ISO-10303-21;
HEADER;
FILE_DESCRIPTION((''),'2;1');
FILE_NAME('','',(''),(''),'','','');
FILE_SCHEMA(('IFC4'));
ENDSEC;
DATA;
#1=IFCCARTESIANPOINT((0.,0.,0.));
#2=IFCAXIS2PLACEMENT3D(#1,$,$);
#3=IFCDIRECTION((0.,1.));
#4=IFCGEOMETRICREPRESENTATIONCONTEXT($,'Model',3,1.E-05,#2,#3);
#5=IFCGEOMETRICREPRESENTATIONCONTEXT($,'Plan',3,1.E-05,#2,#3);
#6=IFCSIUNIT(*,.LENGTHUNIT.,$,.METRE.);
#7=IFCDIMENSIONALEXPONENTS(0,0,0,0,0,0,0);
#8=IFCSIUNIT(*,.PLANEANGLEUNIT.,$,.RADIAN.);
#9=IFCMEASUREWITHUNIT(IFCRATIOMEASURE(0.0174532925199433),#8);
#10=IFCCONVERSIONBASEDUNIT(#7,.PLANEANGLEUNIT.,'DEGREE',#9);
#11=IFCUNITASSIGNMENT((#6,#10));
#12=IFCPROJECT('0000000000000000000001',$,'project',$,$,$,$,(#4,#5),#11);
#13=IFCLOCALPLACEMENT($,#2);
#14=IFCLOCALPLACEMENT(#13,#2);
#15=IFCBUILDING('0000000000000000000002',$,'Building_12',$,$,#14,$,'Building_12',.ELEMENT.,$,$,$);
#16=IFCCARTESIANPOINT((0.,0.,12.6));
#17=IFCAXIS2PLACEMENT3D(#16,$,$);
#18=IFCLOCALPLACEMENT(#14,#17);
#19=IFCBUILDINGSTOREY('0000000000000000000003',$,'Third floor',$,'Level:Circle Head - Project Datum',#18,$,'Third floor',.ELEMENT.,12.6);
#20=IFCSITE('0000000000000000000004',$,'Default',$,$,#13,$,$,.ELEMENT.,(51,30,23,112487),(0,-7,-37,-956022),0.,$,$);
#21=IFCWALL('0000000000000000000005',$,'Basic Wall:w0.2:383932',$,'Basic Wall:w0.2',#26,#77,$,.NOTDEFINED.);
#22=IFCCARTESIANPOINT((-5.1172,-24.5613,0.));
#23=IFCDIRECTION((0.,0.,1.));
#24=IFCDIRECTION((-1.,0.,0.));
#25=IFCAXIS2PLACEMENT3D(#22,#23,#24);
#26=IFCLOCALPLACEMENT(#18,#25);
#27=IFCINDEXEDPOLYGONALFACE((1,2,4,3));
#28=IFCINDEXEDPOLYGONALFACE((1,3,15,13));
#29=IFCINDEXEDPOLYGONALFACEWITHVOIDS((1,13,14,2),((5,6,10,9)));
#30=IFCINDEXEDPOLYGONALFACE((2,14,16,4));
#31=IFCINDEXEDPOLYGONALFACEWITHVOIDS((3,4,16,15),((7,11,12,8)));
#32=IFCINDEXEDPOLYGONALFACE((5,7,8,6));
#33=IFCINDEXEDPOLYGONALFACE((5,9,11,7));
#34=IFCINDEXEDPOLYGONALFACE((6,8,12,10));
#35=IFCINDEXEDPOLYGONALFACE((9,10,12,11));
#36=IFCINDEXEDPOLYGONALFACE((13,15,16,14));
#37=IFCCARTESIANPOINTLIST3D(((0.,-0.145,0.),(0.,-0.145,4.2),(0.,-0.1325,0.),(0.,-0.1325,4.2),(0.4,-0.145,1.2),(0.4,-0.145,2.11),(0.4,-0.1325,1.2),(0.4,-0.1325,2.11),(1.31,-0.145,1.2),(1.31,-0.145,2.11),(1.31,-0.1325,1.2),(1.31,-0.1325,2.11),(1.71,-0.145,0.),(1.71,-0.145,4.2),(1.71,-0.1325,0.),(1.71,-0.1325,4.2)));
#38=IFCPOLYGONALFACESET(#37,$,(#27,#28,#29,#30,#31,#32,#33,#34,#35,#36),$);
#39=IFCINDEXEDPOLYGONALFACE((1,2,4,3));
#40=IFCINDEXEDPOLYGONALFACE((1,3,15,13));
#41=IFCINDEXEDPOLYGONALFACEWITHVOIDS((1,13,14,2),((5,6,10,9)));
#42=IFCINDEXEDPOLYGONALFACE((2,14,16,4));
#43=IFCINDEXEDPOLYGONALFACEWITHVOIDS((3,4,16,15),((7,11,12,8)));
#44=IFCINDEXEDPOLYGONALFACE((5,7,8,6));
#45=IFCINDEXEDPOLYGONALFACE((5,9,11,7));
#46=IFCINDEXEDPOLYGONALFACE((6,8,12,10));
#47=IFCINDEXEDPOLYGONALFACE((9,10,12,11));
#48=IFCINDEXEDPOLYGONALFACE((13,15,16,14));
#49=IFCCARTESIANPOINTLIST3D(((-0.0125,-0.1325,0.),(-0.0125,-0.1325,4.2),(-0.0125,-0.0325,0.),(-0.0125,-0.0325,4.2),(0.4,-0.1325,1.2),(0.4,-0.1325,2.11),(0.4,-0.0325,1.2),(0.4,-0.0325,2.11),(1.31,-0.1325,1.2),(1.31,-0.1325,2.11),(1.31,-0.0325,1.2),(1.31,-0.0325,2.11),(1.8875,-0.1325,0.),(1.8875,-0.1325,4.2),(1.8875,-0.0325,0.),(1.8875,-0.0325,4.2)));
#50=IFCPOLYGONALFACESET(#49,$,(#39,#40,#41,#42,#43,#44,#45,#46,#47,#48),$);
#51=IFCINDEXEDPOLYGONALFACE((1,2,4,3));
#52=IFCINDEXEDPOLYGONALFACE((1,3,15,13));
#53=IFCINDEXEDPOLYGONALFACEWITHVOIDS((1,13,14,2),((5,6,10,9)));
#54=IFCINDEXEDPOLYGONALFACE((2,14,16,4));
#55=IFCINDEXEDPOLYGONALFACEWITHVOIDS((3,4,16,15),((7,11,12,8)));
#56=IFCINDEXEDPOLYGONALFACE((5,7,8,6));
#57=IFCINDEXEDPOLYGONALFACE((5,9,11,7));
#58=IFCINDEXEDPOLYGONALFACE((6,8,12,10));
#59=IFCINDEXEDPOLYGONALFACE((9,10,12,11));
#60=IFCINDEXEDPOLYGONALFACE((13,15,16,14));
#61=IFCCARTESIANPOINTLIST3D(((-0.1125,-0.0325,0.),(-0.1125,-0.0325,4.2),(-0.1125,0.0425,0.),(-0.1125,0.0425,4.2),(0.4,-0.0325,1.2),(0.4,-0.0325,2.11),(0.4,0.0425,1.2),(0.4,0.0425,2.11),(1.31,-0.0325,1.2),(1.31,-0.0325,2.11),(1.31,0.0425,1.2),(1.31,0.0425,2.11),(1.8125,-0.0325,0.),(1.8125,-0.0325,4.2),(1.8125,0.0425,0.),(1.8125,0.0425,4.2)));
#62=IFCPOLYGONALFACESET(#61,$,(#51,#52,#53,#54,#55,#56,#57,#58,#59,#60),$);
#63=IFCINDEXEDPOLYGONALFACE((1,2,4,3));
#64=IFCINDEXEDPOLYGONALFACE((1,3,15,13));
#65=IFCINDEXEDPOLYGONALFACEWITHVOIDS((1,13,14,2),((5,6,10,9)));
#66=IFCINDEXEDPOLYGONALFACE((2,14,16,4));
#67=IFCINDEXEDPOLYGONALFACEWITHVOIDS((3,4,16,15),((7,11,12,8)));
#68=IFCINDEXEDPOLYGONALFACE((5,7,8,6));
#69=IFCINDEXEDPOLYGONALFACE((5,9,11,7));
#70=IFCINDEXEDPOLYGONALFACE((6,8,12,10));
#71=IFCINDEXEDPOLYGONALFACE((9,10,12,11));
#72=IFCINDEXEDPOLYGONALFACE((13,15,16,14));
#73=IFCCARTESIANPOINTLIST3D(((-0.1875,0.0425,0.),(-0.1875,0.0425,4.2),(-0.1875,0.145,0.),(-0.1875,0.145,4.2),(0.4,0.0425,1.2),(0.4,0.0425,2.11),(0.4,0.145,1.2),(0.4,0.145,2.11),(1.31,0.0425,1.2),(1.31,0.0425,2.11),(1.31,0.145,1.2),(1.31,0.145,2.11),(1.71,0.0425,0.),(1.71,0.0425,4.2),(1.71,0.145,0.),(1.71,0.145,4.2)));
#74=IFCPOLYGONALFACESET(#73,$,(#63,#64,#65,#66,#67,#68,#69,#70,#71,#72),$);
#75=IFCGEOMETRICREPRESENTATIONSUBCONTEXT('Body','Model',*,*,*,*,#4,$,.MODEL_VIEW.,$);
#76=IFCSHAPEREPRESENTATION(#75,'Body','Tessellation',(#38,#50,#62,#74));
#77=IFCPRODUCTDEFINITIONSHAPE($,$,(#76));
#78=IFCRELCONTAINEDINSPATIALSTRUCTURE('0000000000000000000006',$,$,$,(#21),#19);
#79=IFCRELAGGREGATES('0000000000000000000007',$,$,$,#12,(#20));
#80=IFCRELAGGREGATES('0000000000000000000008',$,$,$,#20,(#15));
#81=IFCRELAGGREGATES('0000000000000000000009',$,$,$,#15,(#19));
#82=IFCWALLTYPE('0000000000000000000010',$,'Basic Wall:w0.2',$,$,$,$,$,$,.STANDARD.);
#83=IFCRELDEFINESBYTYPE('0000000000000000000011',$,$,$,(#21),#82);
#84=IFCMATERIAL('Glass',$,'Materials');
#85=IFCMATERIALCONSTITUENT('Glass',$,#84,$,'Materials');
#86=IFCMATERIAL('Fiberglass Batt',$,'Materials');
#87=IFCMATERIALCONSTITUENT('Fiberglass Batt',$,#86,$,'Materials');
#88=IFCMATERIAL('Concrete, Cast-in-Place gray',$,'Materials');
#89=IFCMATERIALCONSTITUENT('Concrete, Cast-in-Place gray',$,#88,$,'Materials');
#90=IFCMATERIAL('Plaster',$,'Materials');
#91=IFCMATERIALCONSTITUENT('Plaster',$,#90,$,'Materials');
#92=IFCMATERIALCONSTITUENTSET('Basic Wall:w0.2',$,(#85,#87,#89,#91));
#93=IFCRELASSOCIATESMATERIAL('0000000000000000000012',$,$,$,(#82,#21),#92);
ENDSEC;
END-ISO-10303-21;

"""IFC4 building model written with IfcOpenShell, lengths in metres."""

from ifc_helpers import new_model, entity, si_unit, converted_unit, direction, frame, origin, place, context, subcontext, project, spatial, indexed_curve, outline, extrude, material, constituent, constituent_set, type_object, element, save


model = new_model("IFC4")

# Units and contexts
model_context = context("Model", 3, precision=1e-05, world=origin(), true_north=direction((0.0, 1.0)))
plan_context = context("Plan", 3, precision=1e-05, world=origin(), true_north=direction((0.0, 1.0)))
body_context = subcontext(model_context, "Body", "Model", "MODEL_VIEW")
ifc_project = project(units=[si_unit("LENGTHUNIT", "METRE"), converted_unit("PLANEANGLEUNIT", "DEGREE", entity("IfcRatioMeasure", 0.0174532925199433), si_unit("PLANEANGLEUNIT", "RADIAN"), dimensions=[0, 0, 0, 0, 0, 0, 0])], contexts=[model_context, plan_context])

# Site, building, storey
site_placement = place(None, origin())
site = spatial("IfcSite", under=ifc_project, at=site_placement, Name="Default", CompositionType="ELEMENT", RefLatitude=(51, 30, 23, 112487), RefLongitude=(0, -7, -37, -956022), RefElevation=0.0)
building_placement = place(site_placement, origin())
building = spatial("IfcBuilding", under=site, at=building_placement, Name="Building_12", LongName="Building_12", CompositionType="ELEMENT")
storey_placement = place(building_placement, frame((0.0, 0.0, 12.6)))
storey = spatial("IfcBuildingStorey", under=building, at=storey_placement, Name="Third floor", ObjectType="Level:Circle Head - Project Datum", LongName="Third floor", CompositionType="ELEMENT", Elevation=12.6)

# Shared definitions
ifc_material_1 = material(Name="Glass", Category="Materials")
ifc_constituent_1 = constituent(ifc_material_1, Name="Glass", Category="Materials")
ifc_material_2 = material(Name="Fiberglass Batt", Category="Materials")
ifc_constituent_2 = constituent(ifc_material_2, Name="Fiberglass Batt", Category="Materials")
ifc_material_3 = material(Name="Concrete, Cast-in-Place gray", Category="Materials")
ifc_constituent_3 = constituent(ifc_material_3, Name="Concrete, Cast-in-Place gray", Category="Materials")
ifc_material_4 = material(Name="Plaster", Category="Materials")
ifc_constituent_4 = constituent(ifc_material_4, Name="Plaster", Category="Materials")
ifc_constituent_set = constituent_set(constituents=[ifc_constituent_1, ifc_constituent_2, ifc_constituent_3, ifc_constituent_4], Name="Basic Wall:w0.2")
wall_type = type_object("IfcWallType", Name="Basic Wall:w0.2", PredefinedType="STANDARD", material=ifc_constituent_set)

# Wall, opening
wall_1_placement = place(storey_placement, frame((-5.1172, -24.5613, 0.0), z_axis=(0.0, 0.0, 1.0), x_axis=(-1.0, 0.0, 0.0)))
wall_1 = element("IfcWall", 1, at=wall_1_placement, inside=storey, type_object=wall_type, material=ifc_constituent_set, Name="Basic Wall:w0.2:383932", ObjectType="Basic Wall:w0.2", PredefinedType="NOTDEFINED", context=body_context, shape_type="SweptSolid", body=[
    extrude(outline(indexed_curve([(-2.1, -0.855), (2.1, -0.855), (2.1, 0.855), (-2.1, 0.855), (-2.1, -0.855)], self_intersect=False), holes=[indexed_curve([(-0.9, -0.455), (-0.9, 0.455), (0.01, 0.455), (0.01, -0.455), (-0.9, -0.455)], self_intersect=False)]), frame((0.855, -0.1325, 2.1), z_axis=(0.0, -1.0, 0.0), x_axis=(0.0, 0.0, 1.0)), (0.0, 0.0, 1.0), 0.0125),
    extrude(outline(indexed_curve([(-2.1, -0.95), (2.1, -0.95), (2.1, 0.95), (-2.1, 0.95), (-2.1, -0.95)], self_intersect=False), holes=[indexed_curve([(-0.9, -0.3725), (-0.9, 0.5375), (0.01, 0.5375), (0.01, -0.3725), (-0.9, -0.3725)], self_intersect=False)]), frame((0.9375, -0.0325, 2.1), z_axis=(0.0, -1.0, 0.0), x_axis=(0.0, 0.0, 1.0)), (0.0, 0.0, 1.0), 0.1),
    extrude(outline(indexed_curve([(-2.1, -0.9625), (2.1, -0.9625), (2.1, 0.9625), (-2.1, 0.9625), (-2.1, -0.9625)], self_intersect=False), holes=[indexed_curve([(-0.9, -0.46), (-0.9, 0.45), (0.01, 0.45), (0.01, -0.46), (-0.9, -0.46)], self_intersect=False)]), frame((0.85, 0.0425, 2.1), z_axis=(0.0, -1.0, 0.0), x_axis=(0.0, 0.0, 1.0)), (0.0, 0.0, 1.0), 0.075),
    extrude(outline(indexed_curve([(-0.9487, -2.1), (0.9487, -2.1), (0.9487, 2.1), (-0.9487, 2.1), (-0.9487, -2.1)], self_intersect=False), holes=[indexed_curve([(0.5487, 0.01), (0.5487, -0.9), (-0.3613, -0.9), (-0.3613, 0.01), (0.5487, 0.01)], self_intersect=False)]), frame((0.7612, 0.145, 2.1), z_axis=(0.0, -1.0, 0.0), x_axis=(1.0, 0.0, 0.0)), (0.0, 0.0, 1.0), 0.1025),
])
opening_1_placement = place(wall_1_placement, frame((1.31, 0.145, 1.2)))
element("IfcOpeningElement", 2, at=opening_1_placement, cuts=wall_1, PredefinedType="OPENING", context=body_context, shape_type="SweptSolid", body=[
    extrude(outline(indexed_curve([(0.91, 0.0), (0.91, 0.91), (0.0, 0.91), (0.0, 0.0), (0.91, 0.0)], self_intersect=False)), frame((0.0, 0.0, 0.0), z_axis=(0.0, -1.0, 0.0), x_axis=(0.0, 0.0, 1.0)), (0.0, 0.0, 1.0), 0.29),
])

save(model, "model.ifc")
